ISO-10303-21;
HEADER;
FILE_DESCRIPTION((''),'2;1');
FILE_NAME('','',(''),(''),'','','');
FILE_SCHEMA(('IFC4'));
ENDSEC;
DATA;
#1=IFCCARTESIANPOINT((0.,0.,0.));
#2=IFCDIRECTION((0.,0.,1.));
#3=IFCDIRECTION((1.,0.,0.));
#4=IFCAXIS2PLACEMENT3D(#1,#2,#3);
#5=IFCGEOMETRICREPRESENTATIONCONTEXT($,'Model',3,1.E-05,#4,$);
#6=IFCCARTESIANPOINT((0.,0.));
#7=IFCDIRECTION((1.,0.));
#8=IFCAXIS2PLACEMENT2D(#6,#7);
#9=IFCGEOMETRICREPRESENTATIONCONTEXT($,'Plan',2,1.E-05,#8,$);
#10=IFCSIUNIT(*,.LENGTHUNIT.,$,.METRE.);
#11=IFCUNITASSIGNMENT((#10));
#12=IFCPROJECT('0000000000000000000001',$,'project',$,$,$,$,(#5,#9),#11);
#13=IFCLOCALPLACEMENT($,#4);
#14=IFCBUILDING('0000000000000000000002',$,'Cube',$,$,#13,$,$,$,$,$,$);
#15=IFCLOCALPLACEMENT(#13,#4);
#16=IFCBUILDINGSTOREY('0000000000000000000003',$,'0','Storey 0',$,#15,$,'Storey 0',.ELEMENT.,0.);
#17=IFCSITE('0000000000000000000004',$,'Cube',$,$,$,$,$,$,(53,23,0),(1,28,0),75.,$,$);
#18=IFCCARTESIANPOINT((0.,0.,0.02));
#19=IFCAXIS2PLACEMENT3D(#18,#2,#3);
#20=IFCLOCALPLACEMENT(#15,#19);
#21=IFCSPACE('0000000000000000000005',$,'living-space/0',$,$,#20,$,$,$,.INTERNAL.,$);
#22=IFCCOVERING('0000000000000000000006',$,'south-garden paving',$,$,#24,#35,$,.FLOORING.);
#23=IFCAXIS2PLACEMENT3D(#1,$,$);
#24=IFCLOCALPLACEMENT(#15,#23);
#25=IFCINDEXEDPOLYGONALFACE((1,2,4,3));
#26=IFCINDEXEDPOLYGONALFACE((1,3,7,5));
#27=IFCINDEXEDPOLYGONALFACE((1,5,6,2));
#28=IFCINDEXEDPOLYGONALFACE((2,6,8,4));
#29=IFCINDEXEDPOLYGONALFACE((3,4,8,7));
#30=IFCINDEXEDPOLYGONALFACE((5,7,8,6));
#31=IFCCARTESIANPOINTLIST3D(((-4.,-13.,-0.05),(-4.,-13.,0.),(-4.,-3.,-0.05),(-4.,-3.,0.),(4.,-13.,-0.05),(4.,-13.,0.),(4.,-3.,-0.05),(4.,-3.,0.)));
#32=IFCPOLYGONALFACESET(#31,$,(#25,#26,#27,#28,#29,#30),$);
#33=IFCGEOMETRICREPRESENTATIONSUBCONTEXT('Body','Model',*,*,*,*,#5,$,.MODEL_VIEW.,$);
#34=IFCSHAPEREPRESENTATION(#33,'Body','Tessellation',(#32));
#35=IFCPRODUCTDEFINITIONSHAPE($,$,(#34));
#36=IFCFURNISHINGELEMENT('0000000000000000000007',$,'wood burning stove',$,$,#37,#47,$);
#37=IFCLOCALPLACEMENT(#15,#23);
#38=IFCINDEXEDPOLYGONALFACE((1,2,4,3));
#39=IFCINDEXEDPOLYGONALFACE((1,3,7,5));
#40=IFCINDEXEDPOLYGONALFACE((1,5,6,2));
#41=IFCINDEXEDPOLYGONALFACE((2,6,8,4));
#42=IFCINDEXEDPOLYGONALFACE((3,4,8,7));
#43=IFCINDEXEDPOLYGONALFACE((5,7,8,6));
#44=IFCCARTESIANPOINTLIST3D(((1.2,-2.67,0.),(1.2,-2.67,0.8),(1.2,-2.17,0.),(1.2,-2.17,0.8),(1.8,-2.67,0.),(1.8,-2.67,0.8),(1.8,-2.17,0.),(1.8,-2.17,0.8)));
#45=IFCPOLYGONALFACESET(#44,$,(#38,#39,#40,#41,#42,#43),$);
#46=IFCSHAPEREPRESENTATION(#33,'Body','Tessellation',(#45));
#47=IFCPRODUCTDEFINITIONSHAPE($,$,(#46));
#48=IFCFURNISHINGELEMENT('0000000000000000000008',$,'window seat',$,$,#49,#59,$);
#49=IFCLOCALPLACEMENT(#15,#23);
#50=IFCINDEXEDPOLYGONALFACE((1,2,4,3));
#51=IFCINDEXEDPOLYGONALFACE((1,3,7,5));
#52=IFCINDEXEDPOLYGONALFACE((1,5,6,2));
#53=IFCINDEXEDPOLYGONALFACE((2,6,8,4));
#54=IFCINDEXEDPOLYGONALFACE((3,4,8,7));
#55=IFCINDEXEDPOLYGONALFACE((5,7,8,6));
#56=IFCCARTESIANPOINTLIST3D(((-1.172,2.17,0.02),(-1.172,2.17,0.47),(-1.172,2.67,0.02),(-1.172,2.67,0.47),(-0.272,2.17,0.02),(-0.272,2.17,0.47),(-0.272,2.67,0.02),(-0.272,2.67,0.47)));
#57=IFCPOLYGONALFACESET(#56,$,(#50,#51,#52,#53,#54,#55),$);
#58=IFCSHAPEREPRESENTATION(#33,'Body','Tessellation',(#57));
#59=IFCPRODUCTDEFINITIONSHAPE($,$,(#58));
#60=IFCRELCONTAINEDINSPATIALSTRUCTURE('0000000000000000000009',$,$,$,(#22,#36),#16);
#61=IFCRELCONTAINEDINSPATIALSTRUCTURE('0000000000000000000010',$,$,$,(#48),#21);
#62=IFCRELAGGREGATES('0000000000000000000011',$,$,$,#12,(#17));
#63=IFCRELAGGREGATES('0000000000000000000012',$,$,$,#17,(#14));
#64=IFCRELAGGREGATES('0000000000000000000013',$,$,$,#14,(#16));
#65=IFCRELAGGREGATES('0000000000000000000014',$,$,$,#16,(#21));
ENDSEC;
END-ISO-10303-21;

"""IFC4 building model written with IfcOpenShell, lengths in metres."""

from ifc_helpers import new_model, si_unit, frame, origin_with_axes, origin_2d_with_axis, place, context, subcontext, project, spatial, indexed_curve, outline, extrude, element, save


model = new_model("IFC4")

# Units and contexts
model_context = context("Model", 3, precision=1e-05, world=origin_with_axes())
plan_context = context("Plan", 2, precision=1e-05, world=origin_2d_with_axis())
body_context = subcontext(model_context, "Body", "Model", "MODEL_VIEW")
ifc_project = project(units=[si_unit("LENGTHUNIT", "METRE")], contexts=[model_context, plan_context])

# Site, building, storey
site = spatial("IfcSite", under=ifc_project, Name="Cube", RefLatitude=(53, 23, 0), RefLongitude=(1, 28, 0), RefElevation=75.0)
building_placement = place(None, origin_with_axes())
building = spatial("IfcBuilding", under=site, at=building_placement, Name="Cube")
storey_placement = place(building_placement, origin_with_axes())
storey = spatial("IfcBuildingStorey", under=building, at=storey_placement, Name="0", Description="Storey 0", LongName="Storey 0", CompositionType="ELEMENT", Elevation=0.0)

# Shared definitions
space_placement = place(storey_placement, frame((0.0, 0.0, 0.02), z_axis=(0.0, 0.0, 1.0), x_axis=(1.0, 0.0, 0.0)))
space = spatial("IfcSpace", under=storey, at=space_placement, Name="living-space/0", PredefinedType="INTERNAL")

# Covering
covering_1_placement = place(storey_placement, frame((-4.0, -13.0, 0.0), z_axis=(0.0, 0.0, 1.0), x_axis=(1.0, 0.0, 0.0)))
element("IfcCovering", 1, at=covering_1_placement, inside=storey, Name="south-garden paving", PredefinedType="FLOORING", context=body_context, shape_type="SweptSolid", body=[
    extrude(outline(indexed_curve([(0.0, 0.0), (8.0, 0.0), (8.0, 10.0), (0.0, 10.0)])), None, (0.0, 0.0, -1.0), 0.05),
])

# Furnishing elements
furnishing_1_placement = place(storey_placement, frame((1.2, -2.67, 0.0), z_axis=(0.0, 0.0, 1.0), x_axis=(1.0, 0.0, 0.0)))
element("IfcFurnishingElement", 2, at=furnishing_1_placement, inside=storey, Name="wood burning stove", context=body_context, shape_type="SweptSolid", body=[
    extrude(outline(indexed_curve([(0.0, 0.0), (0.6, 0.0), (0.6, 0.5), (0.0, 0.5)])), None, (0.0, 0.0, 1.0), 0.8),
])
furnishing_2_placement = place(space_placement, frame((-1.172, 2.17, 0.0), z_axis=(0.0, 0.0, 1.0), x_axis=(1.0, 0.0, 0.0)))
element("IfcFurnishingElement", 3, at=furnishing_2_placement, inside=space, Name="window seat", context=body_context, shape_type="SweptSolid", body=[
    extrude(outline(indexed_curve([(0.0, 0.0), (0.9, 0.0), (0.9, 0.5), (0.0, 0.5)])), None, (0.0, 0.0, 1.0), 0.45),
])

save(model, "model.ifc")
